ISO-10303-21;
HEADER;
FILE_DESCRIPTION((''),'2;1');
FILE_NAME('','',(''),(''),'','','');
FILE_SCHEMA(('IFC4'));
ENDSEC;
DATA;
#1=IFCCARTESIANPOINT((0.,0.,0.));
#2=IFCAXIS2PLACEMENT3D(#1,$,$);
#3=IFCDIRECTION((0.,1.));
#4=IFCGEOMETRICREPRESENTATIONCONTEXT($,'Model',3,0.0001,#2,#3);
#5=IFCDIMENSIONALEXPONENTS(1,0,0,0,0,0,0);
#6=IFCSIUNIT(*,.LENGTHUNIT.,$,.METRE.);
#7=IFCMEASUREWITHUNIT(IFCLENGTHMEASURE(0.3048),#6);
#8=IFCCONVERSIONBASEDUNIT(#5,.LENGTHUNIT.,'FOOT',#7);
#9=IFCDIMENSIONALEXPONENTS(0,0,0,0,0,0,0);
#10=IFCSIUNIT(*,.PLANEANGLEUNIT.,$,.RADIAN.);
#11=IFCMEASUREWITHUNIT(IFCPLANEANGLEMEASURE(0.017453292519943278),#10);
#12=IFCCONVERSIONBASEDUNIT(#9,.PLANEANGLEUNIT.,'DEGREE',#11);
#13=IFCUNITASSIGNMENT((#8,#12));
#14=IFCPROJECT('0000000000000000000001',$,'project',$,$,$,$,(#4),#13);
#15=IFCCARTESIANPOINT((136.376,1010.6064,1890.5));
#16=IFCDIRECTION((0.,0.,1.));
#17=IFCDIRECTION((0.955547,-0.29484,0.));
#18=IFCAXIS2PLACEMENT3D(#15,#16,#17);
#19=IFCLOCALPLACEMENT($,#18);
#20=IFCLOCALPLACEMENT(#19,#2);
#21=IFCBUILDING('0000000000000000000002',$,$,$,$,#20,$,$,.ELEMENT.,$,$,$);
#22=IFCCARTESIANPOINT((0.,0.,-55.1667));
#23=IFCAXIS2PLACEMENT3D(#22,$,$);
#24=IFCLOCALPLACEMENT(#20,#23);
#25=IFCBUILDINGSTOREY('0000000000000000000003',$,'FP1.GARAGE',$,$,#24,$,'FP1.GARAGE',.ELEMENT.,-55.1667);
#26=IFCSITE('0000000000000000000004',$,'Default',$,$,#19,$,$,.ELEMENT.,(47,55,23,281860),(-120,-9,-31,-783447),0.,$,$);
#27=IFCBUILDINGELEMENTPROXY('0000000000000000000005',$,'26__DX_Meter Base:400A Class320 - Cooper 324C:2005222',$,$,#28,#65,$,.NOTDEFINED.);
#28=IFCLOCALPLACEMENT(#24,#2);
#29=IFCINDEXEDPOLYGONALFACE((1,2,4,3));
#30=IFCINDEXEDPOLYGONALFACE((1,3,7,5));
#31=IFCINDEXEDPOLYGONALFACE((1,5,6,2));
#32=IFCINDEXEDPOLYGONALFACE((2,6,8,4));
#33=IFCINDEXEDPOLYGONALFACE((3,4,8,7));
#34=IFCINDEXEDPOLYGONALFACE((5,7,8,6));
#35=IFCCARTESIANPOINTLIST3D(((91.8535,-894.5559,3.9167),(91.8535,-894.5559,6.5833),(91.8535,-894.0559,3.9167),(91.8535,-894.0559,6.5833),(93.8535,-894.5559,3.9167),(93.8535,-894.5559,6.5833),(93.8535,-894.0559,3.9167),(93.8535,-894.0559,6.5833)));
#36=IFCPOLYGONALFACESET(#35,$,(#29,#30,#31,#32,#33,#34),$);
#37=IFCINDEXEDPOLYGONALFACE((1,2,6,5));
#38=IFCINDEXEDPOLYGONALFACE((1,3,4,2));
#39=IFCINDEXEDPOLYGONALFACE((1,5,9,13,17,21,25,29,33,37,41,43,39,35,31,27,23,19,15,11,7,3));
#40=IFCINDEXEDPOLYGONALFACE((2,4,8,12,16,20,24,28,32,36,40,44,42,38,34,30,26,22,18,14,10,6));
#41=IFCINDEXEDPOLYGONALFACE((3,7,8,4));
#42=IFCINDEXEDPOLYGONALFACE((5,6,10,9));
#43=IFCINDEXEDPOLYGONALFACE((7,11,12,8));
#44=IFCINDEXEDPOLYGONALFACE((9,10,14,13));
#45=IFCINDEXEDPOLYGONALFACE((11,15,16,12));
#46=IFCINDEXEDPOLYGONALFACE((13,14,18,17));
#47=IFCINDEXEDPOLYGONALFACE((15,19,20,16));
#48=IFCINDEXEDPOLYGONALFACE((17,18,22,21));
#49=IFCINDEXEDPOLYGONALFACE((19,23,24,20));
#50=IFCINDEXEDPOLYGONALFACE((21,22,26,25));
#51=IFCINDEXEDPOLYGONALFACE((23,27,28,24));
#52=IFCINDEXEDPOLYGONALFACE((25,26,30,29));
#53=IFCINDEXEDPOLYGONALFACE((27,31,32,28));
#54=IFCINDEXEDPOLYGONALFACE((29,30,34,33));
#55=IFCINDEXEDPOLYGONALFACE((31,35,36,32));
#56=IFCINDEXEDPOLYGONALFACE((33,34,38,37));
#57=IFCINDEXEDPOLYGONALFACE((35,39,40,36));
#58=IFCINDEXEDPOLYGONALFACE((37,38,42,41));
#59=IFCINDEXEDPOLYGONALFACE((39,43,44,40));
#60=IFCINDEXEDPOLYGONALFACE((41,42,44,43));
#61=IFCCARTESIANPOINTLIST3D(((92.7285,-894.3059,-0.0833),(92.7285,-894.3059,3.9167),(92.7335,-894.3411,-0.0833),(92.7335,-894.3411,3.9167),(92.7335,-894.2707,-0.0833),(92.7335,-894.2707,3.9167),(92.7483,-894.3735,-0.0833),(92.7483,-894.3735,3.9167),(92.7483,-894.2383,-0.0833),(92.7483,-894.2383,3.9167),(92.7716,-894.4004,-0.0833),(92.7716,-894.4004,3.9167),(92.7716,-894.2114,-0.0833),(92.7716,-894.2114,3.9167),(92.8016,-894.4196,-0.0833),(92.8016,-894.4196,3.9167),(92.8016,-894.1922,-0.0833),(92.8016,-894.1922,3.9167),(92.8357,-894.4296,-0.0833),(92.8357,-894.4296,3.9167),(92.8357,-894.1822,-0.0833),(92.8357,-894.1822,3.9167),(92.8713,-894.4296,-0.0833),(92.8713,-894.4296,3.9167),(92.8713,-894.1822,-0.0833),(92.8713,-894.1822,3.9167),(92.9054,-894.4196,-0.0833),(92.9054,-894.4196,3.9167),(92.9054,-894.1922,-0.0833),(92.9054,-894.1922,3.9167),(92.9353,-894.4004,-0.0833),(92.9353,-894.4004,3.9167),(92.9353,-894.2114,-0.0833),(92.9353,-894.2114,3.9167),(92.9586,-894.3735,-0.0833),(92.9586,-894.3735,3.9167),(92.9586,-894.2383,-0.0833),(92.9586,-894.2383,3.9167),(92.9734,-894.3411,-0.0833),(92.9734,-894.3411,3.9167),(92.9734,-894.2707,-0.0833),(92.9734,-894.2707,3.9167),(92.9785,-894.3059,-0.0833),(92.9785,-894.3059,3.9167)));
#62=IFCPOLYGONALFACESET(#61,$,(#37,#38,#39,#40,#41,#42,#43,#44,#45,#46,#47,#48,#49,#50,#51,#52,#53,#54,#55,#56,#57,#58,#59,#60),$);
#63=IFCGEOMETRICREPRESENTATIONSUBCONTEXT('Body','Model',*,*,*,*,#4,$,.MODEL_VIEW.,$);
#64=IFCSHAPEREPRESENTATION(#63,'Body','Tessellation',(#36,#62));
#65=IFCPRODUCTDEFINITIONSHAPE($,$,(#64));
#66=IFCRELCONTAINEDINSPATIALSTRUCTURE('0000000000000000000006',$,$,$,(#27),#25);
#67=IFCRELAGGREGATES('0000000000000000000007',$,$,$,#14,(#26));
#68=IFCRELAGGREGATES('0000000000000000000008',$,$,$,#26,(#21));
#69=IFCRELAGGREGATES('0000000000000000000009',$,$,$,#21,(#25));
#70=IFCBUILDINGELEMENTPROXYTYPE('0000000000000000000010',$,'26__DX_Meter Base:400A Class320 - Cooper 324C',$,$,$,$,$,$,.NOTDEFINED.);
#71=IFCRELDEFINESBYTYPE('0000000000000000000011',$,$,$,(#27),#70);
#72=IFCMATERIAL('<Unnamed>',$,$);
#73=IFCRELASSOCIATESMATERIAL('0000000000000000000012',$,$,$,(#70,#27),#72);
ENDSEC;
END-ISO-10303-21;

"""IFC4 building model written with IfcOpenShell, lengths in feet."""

from ifc_helpers import new_model, entity, si_unit, converted_unit, direction, frame, origin, place, context, subcontext, project, spatial, arc, indexed_curve, outline, extrude, source, transform, mapped, material, type_object, type_shapes, element, save


model = new_model("IFC4")

# Units and contexts
model_context = context("Model", 3, precision=0.0001, world=origin(), true_north=direction((0.0, 1.0)))
body_context = subcontext(model_context, "Body", "Model", "MODEL_VIEW")
ifc_project = project(units=[converted_unit("LENGTHUNIT", "FOOT", entity("IfcLengthMeasure", 0.3048), si_unit("LENGTHUNIT", "METRE"), dimensions=[1, 0, 0, 0, 0, 0, 0]), converted_unit("PLANEANGLEUNIT", "DEGREE", entity("IfcPlaneAngleMeasure", 0.017453292519943278), si_unit("PLANEANGLEUNIT", "RADIAN"), dimensions=[0, 0, 0, 0, 0, 0, 0])], contexts=[model_context])

# Site, building, storey
site_placement = place(None, frame((136.376, 1010.6064, 1890.5), z_axis=(0.0, 0.0, 1.0), x_axis=(0.955547, -0.29484, 0.0)))
site = spatial("IfcSite", under=ifc_project, at=site_placement, Name="Default", CompositionType="ELEMENT", RefLatitude=(47, 55, 23, 281860), RefLongitude=(-120, -9, -31, -783447), RefElevation=0.0)
building_placement = place(site_placement, origin())
building = spatial("IfcBuilding", under=site, at=building_placement, CompositionType="ELEMENT")
storey_placement = place(building_placement, frame((0.0, 0.0, -55.1667)))
storey = spatial("IfcBuildingStorey", under=building, at=storey_placement, Name="FP1.GARAGE", LongName="FP1.GARAGE", CompositionType="ELEMENT", Elevation=-55.1667)

# Shared definitions
ifc_material_1 = material(Name="<Unnamed>")

# Building element proxy
building_element_proxy_type_1 = type_object("IfcBuildingElementProxyType", Name="26__DX_Meter Base:400A Class320 - Cooper 324C", PredefinedType="NOTDEFINED", material=ifc_material_1)
shared_shape_1 = source(origin(), body_context, "Body", "SweptSolid", [
    extrude(outline(indexed_curve([(-0.25, -1.0), (0.25, -1.0), (0.25, 1.0), (-0.25, 1.0), (-0.25, -1.0)], self_intersect=False)), frame((0.0, 0.5833, 0.0), z_axis=(0.0, 0.0, 1.0), x_axis=(0.0, 1.0, 0.0)), (0.0, 0.0, 1.0), 2.6667),
    extrude(outline(indexed_curve([(-0.125, 0.0), (0.0, -0.125), (0.125, 0.0), (0.0, 0.125)], segments=[arc(1, 2, 3), arc(3, 4, 1)], self_intersect=False)), frame((0.0, 0.5833, -4.0)), (0.0, 0.0, 1.0), 4.0),
])
type_shapes(building_element_proxy_type_1, [shared_shape_1])
proxy_1_placement = place(storey_placement, frame((92.8535, -894.8892, 3.9167)))
element("IfcBuildingElementProxy", 1, at=proxy_1_placement, inside=storey, type_object=building_element_proxy_type_1, material=ifc_material_1, Name="26__DX_Meter Base:400A Class320 - Cooper 324C:2005222", PredefinedType="NOTDEFINED", context=body_context, shape_type="MappedRepresentation", body=[
    mapped(shared_shape_1, transform((0.0, 0.0, 0.0), scale=1.0)),
])

save(model, "model.ifc")
